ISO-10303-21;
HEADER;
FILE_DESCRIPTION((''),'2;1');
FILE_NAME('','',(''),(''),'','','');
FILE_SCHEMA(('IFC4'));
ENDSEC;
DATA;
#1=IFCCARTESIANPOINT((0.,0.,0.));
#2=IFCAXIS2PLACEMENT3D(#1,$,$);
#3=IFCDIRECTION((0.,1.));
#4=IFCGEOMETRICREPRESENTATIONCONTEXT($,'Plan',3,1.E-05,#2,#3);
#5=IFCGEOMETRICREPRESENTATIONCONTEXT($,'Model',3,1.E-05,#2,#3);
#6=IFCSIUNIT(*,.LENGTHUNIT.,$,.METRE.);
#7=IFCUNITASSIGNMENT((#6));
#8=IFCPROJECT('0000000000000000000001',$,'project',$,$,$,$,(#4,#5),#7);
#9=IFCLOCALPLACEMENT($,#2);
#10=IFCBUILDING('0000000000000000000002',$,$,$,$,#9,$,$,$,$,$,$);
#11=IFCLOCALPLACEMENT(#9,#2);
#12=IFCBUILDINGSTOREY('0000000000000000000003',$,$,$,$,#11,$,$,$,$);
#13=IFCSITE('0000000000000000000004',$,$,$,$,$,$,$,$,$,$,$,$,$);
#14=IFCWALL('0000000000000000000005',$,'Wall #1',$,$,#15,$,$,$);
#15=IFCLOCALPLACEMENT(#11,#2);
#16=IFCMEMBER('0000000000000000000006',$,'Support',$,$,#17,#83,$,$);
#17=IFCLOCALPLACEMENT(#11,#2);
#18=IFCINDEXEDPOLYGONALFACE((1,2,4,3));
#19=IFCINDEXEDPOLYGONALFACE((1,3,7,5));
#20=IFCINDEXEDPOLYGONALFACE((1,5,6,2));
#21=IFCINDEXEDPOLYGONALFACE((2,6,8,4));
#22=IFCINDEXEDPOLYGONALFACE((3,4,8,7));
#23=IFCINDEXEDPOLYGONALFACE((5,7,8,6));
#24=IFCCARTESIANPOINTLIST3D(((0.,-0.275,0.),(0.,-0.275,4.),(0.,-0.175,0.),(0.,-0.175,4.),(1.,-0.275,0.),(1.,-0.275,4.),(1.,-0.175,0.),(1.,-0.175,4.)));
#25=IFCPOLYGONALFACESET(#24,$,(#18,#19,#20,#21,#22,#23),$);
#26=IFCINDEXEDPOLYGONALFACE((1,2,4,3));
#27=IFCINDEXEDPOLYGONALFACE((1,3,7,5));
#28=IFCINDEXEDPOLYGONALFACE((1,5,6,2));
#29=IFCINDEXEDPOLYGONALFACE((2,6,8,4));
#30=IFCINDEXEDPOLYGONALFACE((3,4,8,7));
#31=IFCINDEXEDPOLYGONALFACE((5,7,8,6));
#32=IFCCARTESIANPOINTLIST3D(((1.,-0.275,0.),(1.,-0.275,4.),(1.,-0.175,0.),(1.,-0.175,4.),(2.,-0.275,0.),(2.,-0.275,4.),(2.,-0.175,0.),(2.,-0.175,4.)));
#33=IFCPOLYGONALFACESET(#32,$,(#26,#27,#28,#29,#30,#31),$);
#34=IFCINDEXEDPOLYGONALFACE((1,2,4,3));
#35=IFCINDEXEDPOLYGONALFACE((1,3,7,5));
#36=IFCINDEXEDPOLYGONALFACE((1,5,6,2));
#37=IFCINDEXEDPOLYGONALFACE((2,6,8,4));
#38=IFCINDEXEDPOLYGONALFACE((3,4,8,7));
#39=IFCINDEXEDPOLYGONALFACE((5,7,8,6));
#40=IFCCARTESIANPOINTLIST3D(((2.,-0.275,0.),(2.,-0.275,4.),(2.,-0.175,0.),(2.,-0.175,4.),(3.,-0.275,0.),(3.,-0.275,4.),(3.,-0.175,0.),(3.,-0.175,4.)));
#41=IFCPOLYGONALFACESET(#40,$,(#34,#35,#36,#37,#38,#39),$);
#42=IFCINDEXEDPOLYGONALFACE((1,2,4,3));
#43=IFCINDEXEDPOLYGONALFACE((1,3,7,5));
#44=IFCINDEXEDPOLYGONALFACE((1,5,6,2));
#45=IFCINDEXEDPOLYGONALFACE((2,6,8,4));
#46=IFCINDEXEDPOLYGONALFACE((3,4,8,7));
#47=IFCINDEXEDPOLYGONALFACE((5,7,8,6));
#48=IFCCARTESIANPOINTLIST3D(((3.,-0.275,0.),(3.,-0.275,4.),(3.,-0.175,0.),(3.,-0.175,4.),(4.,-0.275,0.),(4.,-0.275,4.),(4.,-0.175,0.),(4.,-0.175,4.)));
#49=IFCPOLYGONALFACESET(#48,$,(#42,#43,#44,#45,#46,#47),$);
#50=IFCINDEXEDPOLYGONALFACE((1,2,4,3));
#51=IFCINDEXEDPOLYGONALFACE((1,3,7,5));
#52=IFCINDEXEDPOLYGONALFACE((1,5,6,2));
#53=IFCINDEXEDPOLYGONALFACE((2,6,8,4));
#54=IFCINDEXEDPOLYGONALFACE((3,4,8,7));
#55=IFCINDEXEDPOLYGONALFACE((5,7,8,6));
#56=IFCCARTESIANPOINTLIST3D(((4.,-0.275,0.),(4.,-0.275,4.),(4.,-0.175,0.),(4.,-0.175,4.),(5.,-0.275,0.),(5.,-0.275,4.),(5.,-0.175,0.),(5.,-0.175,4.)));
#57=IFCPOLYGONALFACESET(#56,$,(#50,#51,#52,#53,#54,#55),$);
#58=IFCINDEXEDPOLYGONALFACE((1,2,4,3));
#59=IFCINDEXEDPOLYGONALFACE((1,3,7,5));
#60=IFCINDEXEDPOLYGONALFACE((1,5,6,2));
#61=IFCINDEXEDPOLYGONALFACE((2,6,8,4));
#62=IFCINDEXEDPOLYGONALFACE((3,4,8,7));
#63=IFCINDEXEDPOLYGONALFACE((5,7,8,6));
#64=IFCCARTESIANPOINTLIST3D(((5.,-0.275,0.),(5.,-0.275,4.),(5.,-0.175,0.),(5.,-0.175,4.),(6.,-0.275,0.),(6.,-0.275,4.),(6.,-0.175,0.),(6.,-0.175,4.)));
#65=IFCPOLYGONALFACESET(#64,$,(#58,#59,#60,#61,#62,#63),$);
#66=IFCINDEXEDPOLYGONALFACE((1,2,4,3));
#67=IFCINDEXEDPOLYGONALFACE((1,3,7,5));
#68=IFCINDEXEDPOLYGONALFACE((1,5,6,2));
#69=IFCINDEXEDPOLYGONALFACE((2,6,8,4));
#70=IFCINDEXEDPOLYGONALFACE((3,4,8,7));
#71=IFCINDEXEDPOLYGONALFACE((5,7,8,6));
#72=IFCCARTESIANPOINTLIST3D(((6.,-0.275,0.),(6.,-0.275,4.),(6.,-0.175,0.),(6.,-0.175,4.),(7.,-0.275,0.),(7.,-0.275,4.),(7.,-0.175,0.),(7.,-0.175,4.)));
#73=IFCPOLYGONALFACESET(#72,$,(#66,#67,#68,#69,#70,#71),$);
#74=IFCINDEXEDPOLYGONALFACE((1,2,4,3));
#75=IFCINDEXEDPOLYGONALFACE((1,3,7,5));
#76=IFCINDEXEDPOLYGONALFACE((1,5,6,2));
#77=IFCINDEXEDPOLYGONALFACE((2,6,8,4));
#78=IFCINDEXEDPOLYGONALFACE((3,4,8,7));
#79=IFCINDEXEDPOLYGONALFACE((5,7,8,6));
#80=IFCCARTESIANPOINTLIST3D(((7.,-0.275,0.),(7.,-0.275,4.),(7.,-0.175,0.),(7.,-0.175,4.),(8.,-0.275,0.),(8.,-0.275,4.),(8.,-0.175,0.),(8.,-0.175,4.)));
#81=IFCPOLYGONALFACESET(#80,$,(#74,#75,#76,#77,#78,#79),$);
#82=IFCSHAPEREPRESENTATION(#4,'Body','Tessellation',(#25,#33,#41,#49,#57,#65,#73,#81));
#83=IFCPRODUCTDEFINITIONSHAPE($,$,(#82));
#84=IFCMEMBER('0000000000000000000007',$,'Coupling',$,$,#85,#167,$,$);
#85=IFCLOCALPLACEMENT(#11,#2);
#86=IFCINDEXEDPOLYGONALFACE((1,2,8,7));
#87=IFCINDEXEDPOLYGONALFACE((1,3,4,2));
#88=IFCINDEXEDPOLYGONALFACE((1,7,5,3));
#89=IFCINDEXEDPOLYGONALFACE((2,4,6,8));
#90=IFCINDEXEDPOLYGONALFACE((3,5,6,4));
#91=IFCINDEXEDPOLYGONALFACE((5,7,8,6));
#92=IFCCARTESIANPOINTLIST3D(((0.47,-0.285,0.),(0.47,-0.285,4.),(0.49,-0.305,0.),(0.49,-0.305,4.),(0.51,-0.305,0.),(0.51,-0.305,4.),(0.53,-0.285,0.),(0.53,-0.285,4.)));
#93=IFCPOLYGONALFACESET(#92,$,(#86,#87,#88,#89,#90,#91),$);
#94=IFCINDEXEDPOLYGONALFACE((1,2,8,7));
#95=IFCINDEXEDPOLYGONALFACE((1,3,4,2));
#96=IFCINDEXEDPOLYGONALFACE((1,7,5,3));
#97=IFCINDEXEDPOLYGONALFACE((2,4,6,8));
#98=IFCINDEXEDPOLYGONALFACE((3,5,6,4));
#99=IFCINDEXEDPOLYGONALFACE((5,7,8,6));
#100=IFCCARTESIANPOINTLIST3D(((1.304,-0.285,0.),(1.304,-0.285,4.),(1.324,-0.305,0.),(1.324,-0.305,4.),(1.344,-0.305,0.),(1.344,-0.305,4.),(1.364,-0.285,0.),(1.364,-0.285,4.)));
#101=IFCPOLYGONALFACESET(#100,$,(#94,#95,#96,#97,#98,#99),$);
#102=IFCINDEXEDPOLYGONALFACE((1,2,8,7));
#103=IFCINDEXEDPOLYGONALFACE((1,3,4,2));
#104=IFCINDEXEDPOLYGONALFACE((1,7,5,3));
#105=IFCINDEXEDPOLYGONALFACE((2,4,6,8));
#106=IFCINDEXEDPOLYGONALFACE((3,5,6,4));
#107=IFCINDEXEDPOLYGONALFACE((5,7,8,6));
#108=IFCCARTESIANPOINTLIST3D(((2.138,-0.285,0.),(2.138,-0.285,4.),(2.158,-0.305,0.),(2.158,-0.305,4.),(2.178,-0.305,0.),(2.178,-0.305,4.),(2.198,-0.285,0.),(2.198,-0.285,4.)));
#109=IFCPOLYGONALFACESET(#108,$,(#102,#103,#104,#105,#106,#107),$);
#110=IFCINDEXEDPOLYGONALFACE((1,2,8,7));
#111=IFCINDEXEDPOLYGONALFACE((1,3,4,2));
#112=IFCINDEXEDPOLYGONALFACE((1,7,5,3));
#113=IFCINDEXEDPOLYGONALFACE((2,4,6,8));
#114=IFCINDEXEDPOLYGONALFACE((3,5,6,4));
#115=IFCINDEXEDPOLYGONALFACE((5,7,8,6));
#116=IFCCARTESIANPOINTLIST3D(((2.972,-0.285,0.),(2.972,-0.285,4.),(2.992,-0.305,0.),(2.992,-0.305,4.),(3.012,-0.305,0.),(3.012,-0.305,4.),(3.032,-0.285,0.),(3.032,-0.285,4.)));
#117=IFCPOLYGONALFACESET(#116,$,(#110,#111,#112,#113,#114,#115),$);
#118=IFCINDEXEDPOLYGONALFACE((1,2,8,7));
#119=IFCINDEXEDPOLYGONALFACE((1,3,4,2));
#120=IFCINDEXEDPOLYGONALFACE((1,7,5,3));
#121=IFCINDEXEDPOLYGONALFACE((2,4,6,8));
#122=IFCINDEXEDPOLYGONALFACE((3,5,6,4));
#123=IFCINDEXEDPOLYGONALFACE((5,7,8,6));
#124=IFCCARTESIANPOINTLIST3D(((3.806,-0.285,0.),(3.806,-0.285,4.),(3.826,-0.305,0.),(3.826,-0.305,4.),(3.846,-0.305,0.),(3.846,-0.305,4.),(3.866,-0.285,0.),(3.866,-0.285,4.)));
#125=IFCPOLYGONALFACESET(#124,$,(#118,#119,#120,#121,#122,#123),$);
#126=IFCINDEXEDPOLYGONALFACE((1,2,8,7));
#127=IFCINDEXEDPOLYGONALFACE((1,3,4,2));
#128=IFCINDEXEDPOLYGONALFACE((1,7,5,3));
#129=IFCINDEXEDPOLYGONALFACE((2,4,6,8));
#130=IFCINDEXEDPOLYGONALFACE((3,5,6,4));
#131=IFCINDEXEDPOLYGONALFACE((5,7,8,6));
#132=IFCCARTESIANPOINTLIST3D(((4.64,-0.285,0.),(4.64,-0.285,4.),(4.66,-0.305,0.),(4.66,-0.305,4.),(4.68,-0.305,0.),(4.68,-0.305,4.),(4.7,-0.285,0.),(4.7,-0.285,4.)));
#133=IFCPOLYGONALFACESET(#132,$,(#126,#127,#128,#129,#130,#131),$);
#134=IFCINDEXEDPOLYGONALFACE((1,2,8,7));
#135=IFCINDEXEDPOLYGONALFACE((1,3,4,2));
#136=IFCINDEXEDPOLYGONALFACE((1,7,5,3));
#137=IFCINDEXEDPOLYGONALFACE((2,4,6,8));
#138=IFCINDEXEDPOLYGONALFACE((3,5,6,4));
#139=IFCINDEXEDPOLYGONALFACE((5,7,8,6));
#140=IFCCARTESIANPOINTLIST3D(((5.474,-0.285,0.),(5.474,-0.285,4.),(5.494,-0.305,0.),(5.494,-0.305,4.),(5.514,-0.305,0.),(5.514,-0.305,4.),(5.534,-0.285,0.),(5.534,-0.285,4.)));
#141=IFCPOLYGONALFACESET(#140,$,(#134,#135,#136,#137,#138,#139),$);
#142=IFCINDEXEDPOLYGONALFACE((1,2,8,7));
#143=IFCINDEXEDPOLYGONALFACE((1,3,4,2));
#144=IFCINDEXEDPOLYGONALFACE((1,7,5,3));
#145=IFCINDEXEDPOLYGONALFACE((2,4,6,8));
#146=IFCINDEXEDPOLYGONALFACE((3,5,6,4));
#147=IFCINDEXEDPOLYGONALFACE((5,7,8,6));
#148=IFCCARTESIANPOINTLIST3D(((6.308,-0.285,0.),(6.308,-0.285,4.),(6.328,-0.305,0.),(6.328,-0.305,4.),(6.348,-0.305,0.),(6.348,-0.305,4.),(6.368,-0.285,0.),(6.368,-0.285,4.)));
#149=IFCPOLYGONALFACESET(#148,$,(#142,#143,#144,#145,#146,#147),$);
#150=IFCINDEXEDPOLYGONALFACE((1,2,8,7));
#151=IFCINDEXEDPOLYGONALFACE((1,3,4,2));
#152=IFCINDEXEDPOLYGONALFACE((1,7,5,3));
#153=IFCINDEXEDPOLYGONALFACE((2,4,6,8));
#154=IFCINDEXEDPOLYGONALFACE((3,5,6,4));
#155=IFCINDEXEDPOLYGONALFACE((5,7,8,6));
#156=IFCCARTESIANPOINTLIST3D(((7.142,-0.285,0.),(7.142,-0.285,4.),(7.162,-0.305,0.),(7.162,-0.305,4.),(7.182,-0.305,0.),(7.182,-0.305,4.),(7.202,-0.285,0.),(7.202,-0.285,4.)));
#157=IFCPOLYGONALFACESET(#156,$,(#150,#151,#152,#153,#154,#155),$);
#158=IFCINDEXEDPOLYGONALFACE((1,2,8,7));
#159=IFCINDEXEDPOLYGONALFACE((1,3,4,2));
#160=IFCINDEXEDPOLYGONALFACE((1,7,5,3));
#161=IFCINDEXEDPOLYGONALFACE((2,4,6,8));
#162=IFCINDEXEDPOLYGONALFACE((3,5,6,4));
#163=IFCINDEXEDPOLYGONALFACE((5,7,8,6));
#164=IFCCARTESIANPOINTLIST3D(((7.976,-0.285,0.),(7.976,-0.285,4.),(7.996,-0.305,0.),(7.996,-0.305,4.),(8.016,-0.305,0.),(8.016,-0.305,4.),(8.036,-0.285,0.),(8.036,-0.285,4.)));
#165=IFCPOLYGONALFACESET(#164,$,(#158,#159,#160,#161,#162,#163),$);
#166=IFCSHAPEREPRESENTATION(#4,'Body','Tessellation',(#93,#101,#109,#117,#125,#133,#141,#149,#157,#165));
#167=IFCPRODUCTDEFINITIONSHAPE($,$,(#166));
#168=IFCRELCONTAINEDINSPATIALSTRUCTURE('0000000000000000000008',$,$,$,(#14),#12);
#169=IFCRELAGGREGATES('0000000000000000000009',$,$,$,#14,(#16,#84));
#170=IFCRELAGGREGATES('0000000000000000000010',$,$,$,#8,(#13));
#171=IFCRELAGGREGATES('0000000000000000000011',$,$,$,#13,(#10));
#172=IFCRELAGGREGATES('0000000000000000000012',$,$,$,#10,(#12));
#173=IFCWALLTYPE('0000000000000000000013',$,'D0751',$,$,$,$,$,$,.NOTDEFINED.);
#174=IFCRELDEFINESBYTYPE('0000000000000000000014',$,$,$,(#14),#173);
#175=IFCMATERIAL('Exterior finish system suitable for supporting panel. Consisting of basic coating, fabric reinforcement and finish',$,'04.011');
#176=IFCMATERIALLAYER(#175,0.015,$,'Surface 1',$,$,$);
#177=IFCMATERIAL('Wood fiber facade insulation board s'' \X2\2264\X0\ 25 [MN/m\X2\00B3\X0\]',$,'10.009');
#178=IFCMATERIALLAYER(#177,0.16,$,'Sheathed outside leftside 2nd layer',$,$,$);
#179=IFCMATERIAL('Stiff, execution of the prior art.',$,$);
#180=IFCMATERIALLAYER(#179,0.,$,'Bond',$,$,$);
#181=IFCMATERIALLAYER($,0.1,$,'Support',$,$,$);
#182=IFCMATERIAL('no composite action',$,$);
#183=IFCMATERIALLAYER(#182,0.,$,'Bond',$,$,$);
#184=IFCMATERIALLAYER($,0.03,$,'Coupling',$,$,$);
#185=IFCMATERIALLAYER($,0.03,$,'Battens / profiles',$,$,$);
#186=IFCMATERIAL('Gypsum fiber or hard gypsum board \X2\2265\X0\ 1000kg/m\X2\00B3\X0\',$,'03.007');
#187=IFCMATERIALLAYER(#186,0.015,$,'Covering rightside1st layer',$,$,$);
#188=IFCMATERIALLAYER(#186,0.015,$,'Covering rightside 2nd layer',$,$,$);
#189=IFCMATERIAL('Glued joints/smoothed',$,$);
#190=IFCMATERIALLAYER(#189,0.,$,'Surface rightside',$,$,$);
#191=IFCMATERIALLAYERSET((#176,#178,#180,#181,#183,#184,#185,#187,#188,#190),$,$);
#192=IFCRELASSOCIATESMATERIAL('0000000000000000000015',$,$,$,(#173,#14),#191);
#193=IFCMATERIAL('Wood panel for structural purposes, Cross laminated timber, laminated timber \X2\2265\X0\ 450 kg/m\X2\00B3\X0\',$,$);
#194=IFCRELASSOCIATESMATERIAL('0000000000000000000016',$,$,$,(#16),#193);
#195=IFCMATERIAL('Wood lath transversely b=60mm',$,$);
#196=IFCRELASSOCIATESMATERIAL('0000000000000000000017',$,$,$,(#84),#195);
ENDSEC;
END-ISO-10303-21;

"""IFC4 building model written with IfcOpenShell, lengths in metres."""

from ifc_helpers import new_model, si_unit, direction, frame, frame_2d, origin, place, context, project, spatial, polyline, rectangle, outline, extrude, material, layer, layer_set, type_object, element, aggregate, save


model = new_model("IFC4")

# Units and contexts
plan_context = context("Plan", 3, precision=1e-05, world=origin(), true_north=direction((0.0, 1.0)))
model_context = context("Model", 3, precision=1e-05, world=origin(), true_north=direction((0.0, 1.0)))
ifc_project = project(units=[si_unit("LENGTHUNIT", "METRE")], contexts=[plan_context, model_context])

# Site, building, storey
site = spatial("IfcSite", under=ifc_project)
building_placement = place(None, origin())
building = spatial("IfcBuilding", under=site, at=building_placement)
storey_placement = place(building_placement, origin())
storey = spatial("IfcBuildingStorey", under=building, at=storey_placement)

# Wall, members
ifc_material_1 = material(Name="Exterior finish system suitable for supporting panel. Consisting of basic coating, fabric reinforcement and finish", Category="04.011")
ifc_layer_1 = layer(ifc_material_1, 0.015, Name="Surface 1")
ifc_material_2 = material(Name="Wood fiber facade insulation board s' ≤ 25 [MN/m³]", Category="10.009")
ifc_layer_2 = layer(ifc_material_2, 0.16, Name="Sheathed outside leftside 2nd layer")
ifc_material_3 = material(Name="Stiff, execution of the prior art.")
ifc_layer_3 = layer(ifc_material_3, 0.0, Name="Bond")
ifc_layer_4 = layer(None, 0.1, Name="Support")
ifc_material_4 = material(Name="no composite action")
ifc_layer_5 = layer(ifc_material_4, 0.0, Name="Bond")
ifc_layer_6 = layer(None, 0.03, Name="Coupling")
ifc_layer_7 = layer(None, 0.03, Name="Battens / profiles")
ifc_material_5 = material(Name="Gypsum fiber or hard gypsum board ≥ 1000kg/m³", Category="03.007")
ifc_layer_8 = layer(ifc_material_5, 0.015, Name="Covering rightside1st layer")
ifc_layer_9 = layer(ifc_material_5, 0.015, Name="Covering rightside 2nd layer")
ifc_material_6 = material(Name="Glued joints/smoothed")
ifc_layer_10 = layer(ifc_material_6, 0.0, Name="Surface rightside")
ifc_layer_set = layer_set([ifc_layer_1, ifc_layer_2, ifc_layer_3, ifc_layer_4, ifc_layer_5, ifc_layer_6, ifc_layer_7, ifc_layer_8, ifc_layer_9, ifc_layer_10])
wall_type = type_object("IfcWallType", Name="D0751", PredefinedType="NOTDEFINED", material=ifc_layer_set)
wall_placement = place(None, frame((0.0, 0.0, 0.0), z_axis=(0.0, -1.0, 0.0), x_axis=(1.0, 0.0, 0.0)))
wall = element("IfcWall", 1, at=wall_placement, inside=storey, type_object=wall_type, material=ifc_layer_set, Name="Wall #1")
ifc_material_7 = material(Name="Wood panel for structural purposes, Cross laminated timber, laminated timber ≥ 450 kg/m³")
member_1_placement = place(wall_placement, origin())
member_1 = element("IfcMember", 2, at=member_1_placement, material=ifc_material_7, Name="Support", context=plan_context, shape_type="SweptSolid", body=[
    extrude(rectangle(XDim=1.0, YDim=0.1, at=frame_2d((0.5, 0.05), x_axis=(1.0, 0.0))), frame((0.0, 4.0, 0.175), z_axis=(0.0, -1.0, 0.0), x_axis=(1.0, 0.0, 0.0)), (0.0, 0.0, 1.0), 4.0),
    extrude(rectangle(XDim=1.0, YDim=0.1, at=frame_2d((0.5, 0.05), x_axis=(1.0, 0.0))), frame((1.0, 4.0, 0.175), z_axis=(0.0, -1.0, 0.0), x_axis=(1.0, 0.0, 0.0)), (0.0, 0.0, 1.0), 4.0),
    extrude(rectangle(XDim=1.0, YDim=0.1, at=frame_2d((0.5, 0.05), x_axis=(1.0, 0.0))), frame((2.0, 4.0, 0.175), z_axis=(0.0, -1.0, 0.0), x_axis=(1.0, 0.0, 0.0)), (0.0, 0.0, 1.0), 4.0),
    extrude(rectangle(XDim=1.0, YDim=0.1, at=frame_2d((0.5, 0.05), x_axis=(1.0, 0.0))), frame((3.0, 4.0, 0.175), z_axis=(0.0, -1.0, 0.0), x_axis=(1.0, 0.0, 0.0)), (0.0, 0.0, 1.0), 4.0),
    extrude(rectangle(XDim=1.0, YDim=0.1, at=frame_2d((0.5, 0.05), x_axis=(1.0, 0.0))), frame((4.0, 4.0, 0.175), z_axis=(0.0, -1.0, 0.0), x_axis=(1.0, 0.0, 0.0)), (0.0, 0.0, 1.0), 4.0),
    extrude(rectangle(XDim=1.0, YDim=0.1, at=frame_2d((0.5, 0.05), x_axis=(1.0, 0.0))), frame((5.0, 4.0, 0.175), z_axis=(0.0, -1.0, 0.0), x_axis=(1.0, 0.0, 0.0)), (0.0, 0.0, 1.0), 4.0),
    extrude(rectangle(XDim=1.0, YDim=0.1, at=frame_2d((0.5, 0.05), x_axis=(1.0, 0.0))), frame((6.0, 4.0, 0.175), z_axis=(0.0, -1.0, 0.0), x_axis=(1.0, 0.0, 0.0)), (0.0, 0.0, 1.0), 4.0),
    extrude(rectangle(XDim=1.0, YDim=0.1, at=frame_2d((0.5, 0.05), x_axis=(1.0, 0.0))), frame((7.0, 4.0, 0.175), z_axis=(0.0, -1.0, 0.0), x_axis=(1.0, 0.0, 0.0)), (0.0, 0.0, 1.0), 4.0),
])
ifc_material_8 = material(Name="Wood lath transversely b=60mm")
member_2_placement = place(wall_placement, origin())
member_2 = element("IfcMember", 3, at=member_2_placement, material=ifc_material_8, Name="Coupling", context=plan_context, shape_type="SweptSolid", body=[
    extrude(outline(polyline([(0.0, 0.0), (0.06, 0.0), (0.04, 0.02), (0.02, 0.02), (0.0, 0.0)])), frame((0.47, 4.0, 0.285), z_axis=(0.0, -1.0, 0.0), x_axis=(1.0, 0.0, 0.0)), (0.0, 0.0, 1.0), 4.0),
    extrude(outline(polyline([(0.0, 0.0), (0.06, 0.0), (0.04, 0.02), (0.02, 0.02), (0.0, 0.0)])), frame((1.304, 4.0, 0.285), z_axis=(0.0, -1.0, 0.0), x_axis=(1.0, 0.0, 0.0)), (0.0, 0.0, 1.0), 4.0),
    extrude(outline(polyline([(0.0, 0.0), (0.06, 0.0), (0.04, 0.02), (0.02, 0.02), (0.0, 0.0)])), frame((2.138, 4.0, 0.285), z_axis=(0.0, -1.0, 0.0), x_axis=(1.0, 0.0, 0.0)), (0.0, 0.0, 1.0), 4.0),
    extrude(outline(polyline([(0.0, 0.0), (0.06, 0.0), (0.04, 0.02), (0.02, 0.02), (0.0, 0.0)])), frame((2.972, 4.0, 0.285), z_axis=(0.0, -1.0, 0.0), x_axis=(1.0, 0.0, 0.0)), (0.0, 0.0, 1.0), 4.0),
    extrude(outline(polyline([(0.0, 0.0), (0.06, 0.0), (0.04, 0.02), (0.02, 0.02), (0.0, 0.0)])), frame((3.806, 4.0, 0.285), z_axis=(0.0, -1.0, 0.0), x_axis=(1.0, 0.0, 0.0)), (0.0, 0.0, 1.0), 4.0),
    extrude(outline(polyline([(0.0, 0.0), (0.06, 0.0), (0.04, 0.02), (0.02, 0.02), (0.0, 0.0)])), frame((4.64, 4.0, 0.285), z_axis=(0.0, -1.0, 0.0), x_axis=(1.0, 0.0, 0.0)), (0.0, 0.0, 1.0), 4.0),
    extrude(outline(polyline([(0.0, 0.0), (0.06, 0.0), (0.04, 0.02), (0.02, 0.02), (0.0, 0.0)])), frame((5.474, 4.0, 0.285), z_axis=(0.0, -1.0, 0.0), x_axis=(1.0, 0.0, 0.0)), (0.0, 0.0, 1.0), 4.0),
    extrude(outline(polyline([(0.0, 0.0), (0.06, 0.0), (0.04, 0.02), (0.02, 0.02), (0.0, 0.0)])), frame((6.308, 4.0, 0.285), z_axis=(0.0, -1.0, 0.0), x_axis=(1.0, 0.0, 0.0)), (0.0, 0.0, 1.0), 4.0),
    extrude(outline(polyline([(0.0, 0.0), (0.06, 0.0), (0.04, 0.02), (0.02, 0.02), (0.0, 0.0)])), frame((7.142, 4.0, 0.285), z_axis=(0.0, -1.0, 0.0), x_axis=(1.0, 0.0, 0.0)), (0.0, 0.0, 1.0), 4.0),
    extrude(outline(polyline([(0.0, 0.0), (0.06, 0.0), (0.04, 0.02), (0.02, 0.02), (0.0, 0.0)])), frame((7.976, 4.0, 0.285), z_axis=(0.0, -1.0, 0.0), x_axis=(1.0, 0.0, 0.0)), (0.0, 0.0, 1.0), 4.0),
])
aggregate(wall, [member_1, member_2])

save(model, "model.ifc")
